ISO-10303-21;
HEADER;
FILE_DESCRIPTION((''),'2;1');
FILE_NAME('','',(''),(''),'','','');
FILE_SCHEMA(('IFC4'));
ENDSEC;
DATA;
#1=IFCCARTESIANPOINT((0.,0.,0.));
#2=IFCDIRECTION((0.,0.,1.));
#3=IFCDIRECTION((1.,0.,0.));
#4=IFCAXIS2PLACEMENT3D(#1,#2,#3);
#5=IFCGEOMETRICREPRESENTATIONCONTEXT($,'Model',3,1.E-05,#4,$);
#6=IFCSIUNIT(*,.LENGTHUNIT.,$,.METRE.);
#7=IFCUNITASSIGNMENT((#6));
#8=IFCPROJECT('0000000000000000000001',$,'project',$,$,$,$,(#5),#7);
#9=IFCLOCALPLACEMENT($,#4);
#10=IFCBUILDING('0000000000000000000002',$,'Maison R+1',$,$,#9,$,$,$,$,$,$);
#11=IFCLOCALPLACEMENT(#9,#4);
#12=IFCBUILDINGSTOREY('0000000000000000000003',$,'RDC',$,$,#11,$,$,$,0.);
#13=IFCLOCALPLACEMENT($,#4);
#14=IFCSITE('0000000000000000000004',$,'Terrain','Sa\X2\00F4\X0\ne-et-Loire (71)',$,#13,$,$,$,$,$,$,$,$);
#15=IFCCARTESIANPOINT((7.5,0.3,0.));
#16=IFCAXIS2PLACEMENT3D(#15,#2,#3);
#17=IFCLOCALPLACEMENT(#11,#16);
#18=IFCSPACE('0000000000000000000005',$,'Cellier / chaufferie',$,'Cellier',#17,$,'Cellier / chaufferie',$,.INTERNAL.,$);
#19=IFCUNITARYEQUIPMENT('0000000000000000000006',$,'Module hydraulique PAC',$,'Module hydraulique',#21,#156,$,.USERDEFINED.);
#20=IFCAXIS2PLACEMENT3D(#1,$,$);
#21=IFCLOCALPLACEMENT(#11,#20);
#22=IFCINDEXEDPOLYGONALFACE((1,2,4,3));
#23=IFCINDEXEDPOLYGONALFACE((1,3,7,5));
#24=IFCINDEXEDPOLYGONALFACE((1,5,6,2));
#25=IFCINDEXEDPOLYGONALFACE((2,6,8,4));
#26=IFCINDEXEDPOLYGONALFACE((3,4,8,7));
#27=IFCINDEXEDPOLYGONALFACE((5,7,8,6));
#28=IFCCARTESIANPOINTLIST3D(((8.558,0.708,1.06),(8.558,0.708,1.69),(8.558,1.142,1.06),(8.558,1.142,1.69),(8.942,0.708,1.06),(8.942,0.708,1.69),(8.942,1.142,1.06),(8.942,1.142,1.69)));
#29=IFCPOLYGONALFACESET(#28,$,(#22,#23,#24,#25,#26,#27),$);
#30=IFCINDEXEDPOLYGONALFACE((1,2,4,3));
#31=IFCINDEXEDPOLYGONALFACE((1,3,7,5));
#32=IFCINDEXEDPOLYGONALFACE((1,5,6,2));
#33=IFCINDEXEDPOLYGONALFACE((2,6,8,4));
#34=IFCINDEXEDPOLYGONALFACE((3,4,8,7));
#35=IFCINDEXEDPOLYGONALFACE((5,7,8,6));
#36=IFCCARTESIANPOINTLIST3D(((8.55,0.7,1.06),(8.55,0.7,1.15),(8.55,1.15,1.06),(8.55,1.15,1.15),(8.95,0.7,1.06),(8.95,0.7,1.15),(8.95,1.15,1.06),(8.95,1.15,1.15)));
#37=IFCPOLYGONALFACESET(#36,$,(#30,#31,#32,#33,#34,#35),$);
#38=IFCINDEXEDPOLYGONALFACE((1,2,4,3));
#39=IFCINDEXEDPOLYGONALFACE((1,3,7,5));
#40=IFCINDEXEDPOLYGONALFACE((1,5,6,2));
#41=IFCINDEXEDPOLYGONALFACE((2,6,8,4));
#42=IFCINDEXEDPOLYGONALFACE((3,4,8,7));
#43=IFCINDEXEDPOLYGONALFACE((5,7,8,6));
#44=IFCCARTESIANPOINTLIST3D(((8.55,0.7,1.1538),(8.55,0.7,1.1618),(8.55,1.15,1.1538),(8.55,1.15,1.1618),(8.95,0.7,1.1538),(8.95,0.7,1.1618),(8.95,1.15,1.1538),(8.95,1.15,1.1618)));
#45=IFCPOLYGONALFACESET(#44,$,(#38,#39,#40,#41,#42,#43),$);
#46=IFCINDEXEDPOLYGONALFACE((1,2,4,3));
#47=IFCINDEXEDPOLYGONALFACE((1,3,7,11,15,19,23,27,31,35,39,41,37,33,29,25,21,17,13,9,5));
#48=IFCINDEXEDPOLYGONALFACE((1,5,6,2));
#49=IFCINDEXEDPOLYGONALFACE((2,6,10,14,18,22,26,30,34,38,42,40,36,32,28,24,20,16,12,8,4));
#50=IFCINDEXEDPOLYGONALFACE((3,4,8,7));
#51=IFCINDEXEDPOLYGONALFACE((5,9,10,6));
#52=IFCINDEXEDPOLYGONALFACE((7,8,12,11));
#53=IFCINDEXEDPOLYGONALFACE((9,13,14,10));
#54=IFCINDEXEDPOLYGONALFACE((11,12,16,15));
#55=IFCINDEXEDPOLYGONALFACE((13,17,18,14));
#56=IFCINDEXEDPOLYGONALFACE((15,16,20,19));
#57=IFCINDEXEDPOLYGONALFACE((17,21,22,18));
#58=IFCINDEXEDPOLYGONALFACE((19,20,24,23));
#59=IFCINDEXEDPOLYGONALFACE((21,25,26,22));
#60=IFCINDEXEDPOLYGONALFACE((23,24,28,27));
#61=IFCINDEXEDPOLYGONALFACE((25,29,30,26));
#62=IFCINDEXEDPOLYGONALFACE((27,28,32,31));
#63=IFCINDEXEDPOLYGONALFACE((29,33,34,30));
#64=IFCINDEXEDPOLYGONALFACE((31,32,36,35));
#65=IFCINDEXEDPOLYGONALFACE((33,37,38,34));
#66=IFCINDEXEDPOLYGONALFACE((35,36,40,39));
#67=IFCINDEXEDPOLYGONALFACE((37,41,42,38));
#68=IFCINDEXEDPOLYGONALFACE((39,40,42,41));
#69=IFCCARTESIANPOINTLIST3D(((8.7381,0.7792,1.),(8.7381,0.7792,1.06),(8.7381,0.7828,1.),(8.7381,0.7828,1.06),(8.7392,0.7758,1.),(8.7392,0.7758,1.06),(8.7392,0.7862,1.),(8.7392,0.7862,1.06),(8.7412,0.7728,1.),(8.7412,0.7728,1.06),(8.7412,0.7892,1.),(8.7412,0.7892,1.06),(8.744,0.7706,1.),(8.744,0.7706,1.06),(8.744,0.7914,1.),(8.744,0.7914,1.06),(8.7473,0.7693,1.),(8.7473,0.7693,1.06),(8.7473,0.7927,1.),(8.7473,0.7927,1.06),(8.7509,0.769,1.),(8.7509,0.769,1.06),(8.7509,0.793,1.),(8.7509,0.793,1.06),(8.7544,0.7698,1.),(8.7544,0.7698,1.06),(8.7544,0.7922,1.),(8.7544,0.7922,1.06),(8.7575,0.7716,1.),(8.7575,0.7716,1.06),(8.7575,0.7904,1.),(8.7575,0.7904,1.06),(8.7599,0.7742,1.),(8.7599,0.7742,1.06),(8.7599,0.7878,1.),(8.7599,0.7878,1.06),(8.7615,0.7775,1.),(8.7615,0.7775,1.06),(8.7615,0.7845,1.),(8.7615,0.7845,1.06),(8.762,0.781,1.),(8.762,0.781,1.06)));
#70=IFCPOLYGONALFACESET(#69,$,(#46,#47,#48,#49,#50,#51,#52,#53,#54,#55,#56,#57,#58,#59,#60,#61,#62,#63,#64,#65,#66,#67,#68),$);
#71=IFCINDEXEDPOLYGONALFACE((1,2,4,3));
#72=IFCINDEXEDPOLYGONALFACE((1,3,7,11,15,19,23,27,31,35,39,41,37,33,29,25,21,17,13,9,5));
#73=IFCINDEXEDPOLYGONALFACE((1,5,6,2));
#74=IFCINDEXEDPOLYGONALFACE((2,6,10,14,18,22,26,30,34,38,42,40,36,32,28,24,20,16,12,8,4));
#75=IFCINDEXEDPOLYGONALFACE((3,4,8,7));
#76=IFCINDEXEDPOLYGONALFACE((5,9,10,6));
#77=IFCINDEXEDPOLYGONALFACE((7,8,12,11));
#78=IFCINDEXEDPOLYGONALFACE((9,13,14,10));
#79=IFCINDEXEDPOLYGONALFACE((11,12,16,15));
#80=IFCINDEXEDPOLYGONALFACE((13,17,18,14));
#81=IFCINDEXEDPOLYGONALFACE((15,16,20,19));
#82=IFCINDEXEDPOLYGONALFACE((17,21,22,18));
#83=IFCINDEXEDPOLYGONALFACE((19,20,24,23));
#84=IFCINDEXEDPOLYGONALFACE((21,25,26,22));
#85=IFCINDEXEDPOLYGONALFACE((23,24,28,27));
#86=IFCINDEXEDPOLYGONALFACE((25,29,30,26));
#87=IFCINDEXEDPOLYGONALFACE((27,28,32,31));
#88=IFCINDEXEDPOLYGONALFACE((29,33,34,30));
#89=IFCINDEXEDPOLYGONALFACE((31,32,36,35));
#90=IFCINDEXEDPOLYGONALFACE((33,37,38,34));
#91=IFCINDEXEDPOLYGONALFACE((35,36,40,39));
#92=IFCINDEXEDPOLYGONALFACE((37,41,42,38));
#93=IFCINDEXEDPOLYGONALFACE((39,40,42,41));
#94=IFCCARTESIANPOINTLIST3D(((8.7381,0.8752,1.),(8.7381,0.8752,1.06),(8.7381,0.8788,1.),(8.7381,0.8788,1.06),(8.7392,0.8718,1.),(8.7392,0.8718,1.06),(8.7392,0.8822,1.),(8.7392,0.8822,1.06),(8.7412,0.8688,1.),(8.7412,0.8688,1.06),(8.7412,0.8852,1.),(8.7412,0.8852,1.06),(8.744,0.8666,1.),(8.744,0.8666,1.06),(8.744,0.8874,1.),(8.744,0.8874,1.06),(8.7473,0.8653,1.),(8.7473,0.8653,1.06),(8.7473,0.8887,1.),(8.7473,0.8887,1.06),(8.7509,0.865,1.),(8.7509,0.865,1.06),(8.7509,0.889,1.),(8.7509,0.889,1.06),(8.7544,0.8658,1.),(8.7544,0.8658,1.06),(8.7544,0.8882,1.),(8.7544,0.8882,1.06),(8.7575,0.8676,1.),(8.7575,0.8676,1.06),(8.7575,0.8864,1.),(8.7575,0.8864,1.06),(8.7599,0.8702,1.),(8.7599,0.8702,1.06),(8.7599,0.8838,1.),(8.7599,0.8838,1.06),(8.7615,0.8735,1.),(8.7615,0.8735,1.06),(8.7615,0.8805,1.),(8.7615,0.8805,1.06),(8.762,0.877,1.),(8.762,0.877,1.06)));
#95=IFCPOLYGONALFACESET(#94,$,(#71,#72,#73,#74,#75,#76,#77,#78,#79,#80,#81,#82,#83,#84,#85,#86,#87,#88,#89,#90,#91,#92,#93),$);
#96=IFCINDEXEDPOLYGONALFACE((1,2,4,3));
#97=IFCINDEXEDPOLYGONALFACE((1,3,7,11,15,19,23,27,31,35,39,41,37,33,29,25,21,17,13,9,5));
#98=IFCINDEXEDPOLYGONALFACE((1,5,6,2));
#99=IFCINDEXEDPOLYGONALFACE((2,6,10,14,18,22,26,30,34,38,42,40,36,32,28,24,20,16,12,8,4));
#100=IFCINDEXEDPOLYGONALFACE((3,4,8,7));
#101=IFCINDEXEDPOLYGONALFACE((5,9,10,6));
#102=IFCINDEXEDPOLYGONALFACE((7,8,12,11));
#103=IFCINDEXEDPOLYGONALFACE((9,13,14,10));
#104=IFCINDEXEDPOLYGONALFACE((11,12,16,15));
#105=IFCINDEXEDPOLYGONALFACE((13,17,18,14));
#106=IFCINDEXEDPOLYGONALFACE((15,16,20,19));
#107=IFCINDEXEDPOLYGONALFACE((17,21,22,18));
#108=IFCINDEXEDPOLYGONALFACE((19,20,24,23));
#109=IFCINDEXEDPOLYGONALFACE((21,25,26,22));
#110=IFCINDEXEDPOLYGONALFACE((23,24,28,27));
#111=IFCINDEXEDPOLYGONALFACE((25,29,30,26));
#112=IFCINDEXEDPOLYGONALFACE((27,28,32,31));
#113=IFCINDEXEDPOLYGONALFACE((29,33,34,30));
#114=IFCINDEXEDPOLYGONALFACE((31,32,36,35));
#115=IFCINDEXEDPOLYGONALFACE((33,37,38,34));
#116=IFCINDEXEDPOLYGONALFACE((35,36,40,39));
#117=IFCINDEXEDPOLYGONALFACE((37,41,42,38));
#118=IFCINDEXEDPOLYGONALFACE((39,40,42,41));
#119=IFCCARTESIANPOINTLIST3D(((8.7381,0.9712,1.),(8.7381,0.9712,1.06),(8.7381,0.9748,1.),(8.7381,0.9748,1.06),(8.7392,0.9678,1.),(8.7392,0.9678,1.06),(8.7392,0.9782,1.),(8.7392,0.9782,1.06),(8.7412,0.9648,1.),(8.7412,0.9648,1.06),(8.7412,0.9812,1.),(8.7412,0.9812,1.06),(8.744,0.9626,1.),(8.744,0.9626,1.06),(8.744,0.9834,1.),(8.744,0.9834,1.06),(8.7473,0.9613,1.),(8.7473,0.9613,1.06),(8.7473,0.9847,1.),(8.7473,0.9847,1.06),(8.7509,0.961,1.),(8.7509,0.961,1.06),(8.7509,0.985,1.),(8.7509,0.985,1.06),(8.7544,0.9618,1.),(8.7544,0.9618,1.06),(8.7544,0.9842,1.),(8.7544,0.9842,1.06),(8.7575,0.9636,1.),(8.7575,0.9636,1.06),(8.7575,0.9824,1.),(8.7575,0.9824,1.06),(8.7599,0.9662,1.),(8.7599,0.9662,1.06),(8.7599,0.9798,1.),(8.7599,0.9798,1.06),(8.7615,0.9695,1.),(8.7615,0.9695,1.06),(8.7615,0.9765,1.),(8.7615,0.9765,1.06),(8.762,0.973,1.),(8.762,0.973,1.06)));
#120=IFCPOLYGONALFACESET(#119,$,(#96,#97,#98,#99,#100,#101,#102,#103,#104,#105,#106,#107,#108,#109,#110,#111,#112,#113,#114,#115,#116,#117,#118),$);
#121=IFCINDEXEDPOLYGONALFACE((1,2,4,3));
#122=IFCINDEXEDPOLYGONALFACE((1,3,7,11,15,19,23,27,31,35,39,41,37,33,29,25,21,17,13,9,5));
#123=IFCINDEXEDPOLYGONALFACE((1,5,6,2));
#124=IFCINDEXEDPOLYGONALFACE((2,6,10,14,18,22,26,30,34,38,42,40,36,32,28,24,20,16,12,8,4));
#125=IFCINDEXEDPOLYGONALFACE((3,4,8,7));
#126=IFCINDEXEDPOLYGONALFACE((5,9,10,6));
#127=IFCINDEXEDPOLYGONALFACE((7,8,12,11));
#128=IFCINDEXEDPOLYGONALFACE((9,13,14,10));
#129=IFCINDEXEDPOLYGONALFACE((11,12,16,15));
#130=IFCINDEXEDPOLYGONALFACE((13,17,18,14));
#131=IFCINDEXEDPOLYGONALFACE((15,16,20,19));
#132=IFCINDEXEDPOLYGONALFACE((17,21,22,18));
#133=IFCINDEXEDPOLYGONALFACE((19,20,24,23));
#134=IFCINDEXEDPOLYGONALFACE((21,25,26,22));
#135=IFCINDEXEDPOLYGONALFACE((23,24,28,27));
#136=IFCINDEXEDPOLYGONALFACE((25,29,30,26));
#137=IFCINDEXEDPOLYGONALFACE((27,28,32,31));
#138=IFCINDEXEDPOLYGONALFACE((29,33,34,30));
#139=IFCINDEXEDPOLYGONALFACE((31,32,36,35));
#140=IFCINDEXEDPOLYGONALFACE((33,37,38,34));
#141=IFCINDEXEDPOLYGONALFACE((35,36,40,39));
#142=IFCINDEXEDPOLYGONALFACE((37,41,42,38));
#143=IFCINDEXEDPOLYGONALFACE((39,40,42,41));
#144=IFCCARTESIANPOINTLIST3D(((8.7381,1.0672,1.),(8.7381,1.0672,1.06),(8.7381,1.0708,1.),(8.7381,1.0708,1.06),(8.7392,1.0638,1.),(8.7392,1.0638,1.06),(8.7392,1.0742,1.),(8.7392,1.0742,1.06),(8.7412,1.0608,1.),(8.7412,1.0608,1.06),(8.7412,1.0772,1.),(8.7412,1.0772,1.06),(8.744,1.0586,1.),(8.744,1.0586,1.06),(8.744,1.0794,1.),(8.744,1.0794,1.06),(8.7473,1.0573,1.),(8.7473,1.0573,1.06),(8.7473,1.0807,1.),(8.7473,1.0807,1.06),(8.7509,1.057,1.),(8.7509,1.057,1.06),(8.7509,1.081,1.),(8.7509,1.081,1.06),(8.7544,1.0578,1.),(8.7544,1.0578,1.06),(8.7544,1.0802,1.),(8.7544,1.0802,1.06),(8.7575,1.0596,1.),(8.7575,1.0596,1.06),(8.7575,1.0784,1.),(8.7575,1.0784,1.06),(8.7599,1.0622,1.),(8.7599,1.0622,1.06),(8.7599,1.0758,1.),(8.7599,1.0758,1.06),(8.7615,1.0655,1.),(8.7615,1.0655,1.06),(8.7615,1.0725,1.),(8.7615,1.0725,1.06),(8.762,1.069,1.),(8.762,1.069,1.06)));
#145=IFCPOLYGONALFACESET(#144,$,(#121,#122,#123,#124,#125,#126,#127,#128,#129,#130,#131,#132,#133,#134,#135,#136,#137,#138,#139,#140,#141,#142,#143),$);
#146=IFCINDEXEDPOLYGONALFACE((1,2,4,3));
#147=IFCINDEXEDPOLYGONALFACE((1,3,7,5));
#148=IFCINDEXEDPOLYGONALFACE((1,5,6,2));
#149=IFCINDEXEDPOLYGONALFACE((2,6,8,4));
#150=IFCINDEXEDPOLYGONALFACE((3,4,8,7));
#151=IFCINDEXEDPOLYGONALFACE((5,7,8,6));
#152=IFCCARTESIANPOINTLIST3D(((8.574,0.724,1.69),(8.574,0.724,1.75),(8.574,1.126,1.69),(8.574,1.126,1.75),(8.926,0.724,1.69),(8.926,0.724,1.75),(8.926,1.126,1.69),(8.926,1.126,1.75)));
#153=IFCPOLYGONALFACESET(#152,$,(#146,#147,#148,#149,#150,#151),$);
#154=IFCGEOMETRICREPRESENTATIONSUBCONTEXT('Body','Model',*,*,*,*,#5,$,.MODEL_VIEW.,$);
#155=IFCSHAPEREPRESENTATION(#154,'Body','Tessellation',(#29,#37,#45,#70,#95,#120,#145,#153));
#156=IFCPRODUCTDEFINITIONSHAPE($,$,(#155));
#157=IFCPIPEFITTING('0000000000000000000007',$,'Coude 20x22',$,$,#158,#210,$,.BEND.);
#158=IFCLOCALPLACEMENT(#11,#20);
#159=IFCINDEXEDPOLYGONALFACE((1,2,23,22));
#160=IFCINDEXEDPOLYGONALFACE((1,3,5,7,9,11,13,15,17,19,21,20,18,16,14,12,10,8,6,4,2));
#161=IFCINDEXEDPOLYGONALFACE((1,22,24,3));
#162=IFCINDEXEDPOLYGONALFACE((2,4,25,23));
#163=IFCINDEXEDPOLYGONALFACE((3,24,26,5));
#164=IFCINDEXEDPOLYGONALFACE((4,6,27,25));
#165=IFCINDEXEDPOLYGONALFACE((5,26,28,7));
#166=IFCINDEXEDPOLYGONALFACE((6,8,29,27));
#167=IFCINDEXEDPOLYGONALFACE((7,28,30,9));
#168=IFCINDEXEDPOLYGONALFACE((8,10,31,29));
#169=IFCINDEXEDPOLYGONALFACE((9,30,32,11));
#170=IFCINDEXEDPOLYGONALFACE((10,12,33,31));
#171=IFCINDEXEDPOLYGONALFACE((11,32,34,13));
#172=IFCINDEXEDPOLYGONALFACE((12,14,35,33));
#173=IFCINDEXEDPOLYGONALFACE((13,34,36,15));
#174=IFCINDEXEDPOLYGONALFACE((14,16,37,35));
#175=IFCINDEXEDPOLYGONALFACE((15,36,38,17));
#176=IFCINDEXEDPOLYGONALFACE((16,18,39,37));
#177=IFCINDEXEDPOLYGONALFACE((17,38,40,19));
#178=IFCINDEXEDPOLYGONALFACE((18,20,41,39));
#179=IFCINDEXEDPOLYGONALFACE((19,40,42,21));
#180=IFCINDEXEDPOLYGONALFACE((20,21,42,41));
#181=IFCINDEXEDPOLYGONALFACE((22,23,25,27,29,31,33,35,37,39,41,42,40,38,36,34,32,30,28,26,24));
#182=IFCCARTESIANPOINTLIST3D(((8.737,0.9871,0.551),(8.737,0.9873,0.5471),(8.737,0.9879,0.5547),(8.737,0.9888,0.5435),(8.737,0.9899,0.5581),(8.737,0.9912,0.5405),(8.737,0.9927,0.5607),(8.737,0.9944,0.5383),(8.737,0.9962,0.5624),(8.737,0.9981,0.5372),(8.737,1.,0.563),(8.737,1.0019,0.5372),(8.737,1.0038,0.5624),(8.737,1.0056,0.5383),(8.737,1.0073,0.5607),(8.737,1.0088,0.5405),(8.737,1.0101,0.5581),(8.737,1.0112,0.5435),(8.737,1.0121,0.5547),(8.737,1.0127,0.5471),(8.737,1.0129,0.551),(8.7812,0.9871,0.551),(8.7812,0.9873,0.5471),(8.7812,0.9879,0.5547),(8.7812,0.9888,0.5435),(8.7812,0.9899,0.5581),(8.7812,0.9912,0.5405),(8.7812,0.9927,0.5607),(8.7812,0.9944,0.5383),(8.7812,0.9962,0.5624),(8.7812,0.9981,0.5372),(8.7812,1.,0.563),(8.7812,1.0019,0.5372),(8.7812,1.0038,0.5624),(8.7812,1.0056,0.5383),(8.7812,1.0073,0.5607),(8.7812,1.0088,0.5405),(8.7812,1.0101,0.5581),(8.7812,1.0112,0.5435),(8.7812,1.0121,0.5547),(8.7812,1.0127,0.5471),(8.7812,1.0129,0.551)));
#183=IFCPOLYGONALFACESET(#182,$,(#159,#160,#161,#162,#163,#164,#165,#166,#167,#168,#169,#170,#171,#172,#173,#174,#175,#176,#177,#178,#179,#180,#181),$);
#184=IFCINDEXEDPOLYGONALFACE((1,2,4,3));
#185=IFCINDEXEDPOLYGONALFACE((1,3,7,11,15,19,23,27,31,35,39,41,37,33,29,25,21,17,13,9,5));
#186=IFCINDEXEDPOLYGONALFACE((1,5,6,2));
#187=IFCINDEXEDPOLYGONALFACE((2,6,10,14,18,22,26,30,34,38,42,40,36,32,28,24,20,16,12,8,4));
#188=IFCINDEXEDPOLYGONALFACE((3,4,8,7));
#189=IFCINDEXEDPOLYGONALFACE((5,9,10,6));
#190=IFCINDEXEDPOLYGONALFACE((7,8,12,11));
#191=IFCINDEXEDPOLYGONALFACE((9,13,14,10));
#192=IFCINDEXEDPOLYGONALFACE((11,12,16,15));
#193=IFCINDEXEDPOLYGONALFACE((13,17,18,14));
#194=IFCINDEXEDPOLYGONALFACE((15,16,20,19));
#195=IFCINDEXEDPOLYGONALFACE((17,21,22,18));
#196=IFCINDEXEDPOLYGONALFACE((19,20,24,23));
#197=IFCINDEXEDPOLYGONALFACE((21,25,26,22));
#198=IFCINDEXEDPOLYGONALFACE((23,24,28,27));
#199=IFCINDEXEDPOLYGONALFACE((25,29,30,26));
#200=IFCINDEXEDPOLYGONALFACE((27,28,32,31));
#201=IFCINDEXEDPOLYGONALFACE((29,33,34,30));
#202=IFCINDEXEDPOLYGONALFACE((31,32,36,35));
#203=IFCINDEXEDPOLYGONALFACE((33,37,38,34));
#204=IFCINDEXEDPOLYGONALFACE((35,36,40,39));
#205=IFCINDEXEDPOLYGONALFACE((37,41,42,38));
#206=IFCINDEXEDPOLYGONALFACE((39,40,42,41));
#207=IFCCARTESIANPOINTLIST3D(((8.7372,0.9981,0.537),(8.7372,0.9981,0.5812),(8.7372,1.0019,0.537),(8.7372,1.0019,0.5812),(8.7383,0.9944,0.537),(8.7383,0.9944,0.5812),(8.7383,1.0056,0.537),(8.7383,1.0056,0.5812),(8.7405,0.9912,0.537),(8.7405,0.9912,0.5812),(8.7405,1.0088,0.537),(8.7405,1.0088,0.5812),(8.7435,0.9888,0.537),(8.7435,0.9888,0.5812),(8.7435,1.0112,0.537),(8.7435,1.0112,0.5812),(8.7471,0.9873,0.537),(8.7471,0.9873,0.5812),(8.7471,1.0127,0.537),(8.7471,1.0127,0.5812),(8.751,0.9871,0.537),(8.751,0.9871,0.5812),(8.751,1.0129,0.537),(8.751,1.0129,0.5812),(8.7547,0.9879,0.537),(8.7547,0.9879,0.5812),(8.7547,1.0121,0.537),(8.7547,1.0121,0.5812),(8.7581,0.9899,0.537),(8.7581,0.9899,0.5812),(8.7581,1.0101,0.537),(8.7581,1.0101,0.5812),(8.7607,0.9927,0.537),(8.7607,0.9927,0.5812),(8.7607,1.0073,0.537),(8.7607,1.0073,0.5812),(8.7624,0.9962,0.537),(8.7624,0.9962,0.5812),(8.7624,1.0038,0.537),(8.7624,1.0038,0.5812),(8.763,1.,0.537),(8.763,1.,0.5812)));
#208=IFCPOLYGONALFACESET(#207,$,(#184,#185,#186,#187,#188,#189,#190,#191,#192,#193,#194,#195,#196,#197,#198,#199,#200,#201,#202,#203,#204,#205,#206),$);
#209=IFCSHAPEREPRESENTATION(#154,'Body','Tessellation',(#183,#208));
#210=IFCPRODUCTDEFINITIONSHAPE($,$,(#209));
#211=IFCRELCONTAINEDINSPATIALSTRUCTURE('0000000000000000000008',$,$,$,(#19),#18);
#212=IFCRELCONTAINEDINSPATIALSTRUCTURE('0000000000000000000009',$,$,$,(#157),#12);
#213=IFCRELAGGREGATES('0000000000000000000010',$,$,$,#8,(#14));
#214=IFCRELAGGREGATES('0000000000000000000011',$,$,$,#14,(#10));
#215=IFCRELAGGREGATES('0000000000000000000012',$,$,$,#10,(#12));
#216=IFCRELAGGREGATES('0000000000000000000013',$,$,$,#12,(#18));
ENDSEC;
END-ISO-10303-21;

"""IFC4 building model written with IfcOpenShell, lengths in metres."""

from ifc_helpers import new_model, si_unit, frame, frame_2d, origin_with_axes, place, context, subcontext, project, spatial, rectangle, circle, extrude, element, save


model = new_model("IFC4")

# Units and contexts
model_context = context("Model", 3, precision=1e-05, world=origin_with_axes())
body_context = subcontext(model_context, "Body", "Model", "MODEL_VIEW")
ifc_project = project(units=[si_unit("LENGTHUNIT", "METRE")], contexts=[model_context])

# Site, building, storey
site_placement = place(None, origin_with_axes())
site = spatial("IfcSite", under=ifc_project, at=site_placement, Name="Terrain", Description="Saône-et-Loire (71)")
building_placement = place(None, origin_with_axes())
building = spatial("IfcBuilding", under=site, at=building_placement, Name="Maison R+1")
storey_placement = place(building_placement, origin_with_axes())
storey = spatial("IfcBuildingStorey", under=building, at=storey_placement, Name="RDC", Elevation=0.0)

# Shared definitions
space_placement = place(storey_placement, frame((7.5, 0.3, 0.0), z_axis=(0.0, 0.0, 1.0), x_axis=(1.0, 0.0, 0.0)))
space = spatial("IfcSpace", under=storey, at=space_placement, Name="Cellier / chaufferie", ObjectType="Cellier", LongName="Cellier / chaufferie", PredefinedType="INTERNAL")

# Unitary equipment
unitary_equipment_1_placement = place(space_placement, frame((1.05, 0.4, 1.0), z_axis=(0.0, 0.0, 1.0), x_axis=(1.0, 0.0, 0.0)))
element("IfcUnitaryEquipment", 1, at=unitary_equipment_1_placement, inside=space, Name="Module hydraulique PAC", ObjectType="Module hydraulique", PredefinedType="USERDEFINED", context=body_context, shape_type="SweptSolid", body=[
    extrude(rectangle(XDim=0.384, YDim=0.434, at=frame_2d((0.192, 0.217))), frame((0.008, 0.008, 0.06), z_axis=(0.0, 0.0, 1.0), x_axis=(1.0, 0.0, 0.0)), (0.0, 0.0, 1.0), 0.63),
    extrude(rectangle(XDim=0.4, YDim=0.45, at=frame_2d((0.2, 0.225))), frame((0.0, 0.0, 0.06), z_axis=(0.0, 0.0, 1.0), x_axis=(1.0, 0.0, 0.0)), (0.0, 0.0, 1.0), 0.09),
    extrude(rectangle(XDim=0.4, YDim=0.45, at=frame_2d((0.2, 0.225))), frame((0.0, 0.0, 0.1537), z_axis=(0.0, 0.0, 1.0), x_axis=(1.0, 0.0, 0.0)), (0.0, 0.0, 1.0), 0.008),
    extrude(circle(Radius=0.012), frame((0.2, 0.081, 0.0), z_axis=(0.0, 0.0, 1.0), x_axis=(1.0, 0.0, 0.0)), (0.0, 0.0, 1.0), 0.06),
    extrude(circle(Radius=0.012), frame((0.2, 0.177, 0.0), z_axis=(0.0, 0.0, 1.0), x_axis=(1.0, 0.0, 0.0)), (0.0, 0.0, 1.0), 0.06),
    extrude(circle(Radius=0.012), frame((0.2, 0.273, 0.0), z_axis=(0.0, 0.0, 1.0), x_axis=(1.0, 0.0, 0.0)), (0.0, 0.0, 1.0), 0.06),
    extrude(circle(Radius=0.012), frame((0.2, 0.369, 0.0), z_axis=(0.0, 0.0, 1.0), x_axis=(1.0, 0.0, 0.0)), (0.0, 0.0, 1.0), 0.06),
    extrude(rectangle(XDim=0.352, YDim=0.402, at=frame_2d((0.176, 0.201))), frame((0.024, 0.024, 0.69), z_axis=(0.0, 0.0, 1.0), x_axis=(1.0, 0.0, 0.0)), (0.0, 0.0, 1.0), 0.06),
])

# Pipe fitting
for number, where, z_axis, x_axis, name in (
    (2, (8.75, 1.0, 0.55), (0.0, 0.0, 1.0), (1.0, 0.0, 0.0), "Coude 20x22"),
):
    element("IfcPipeFitting", number, at=place(storey_placement, frame(where, z_axis=z_axis, x_axis=x_axis)), inside=storey, Name=name, PredefinedType="BEND", context=body_context, shape_type="SweptSolid", body=[
        extrude(circle(Radius=0.013), frame((-0.013, 0.0, 0.0), z_axis=(1.0, 0.0, 0.0), x_axis=(0.0, 0.0, 1.0)), (0.0, 0.0, 1.0), 0.0441),
        extrude(circle(Radius=0.013), frame((0.0, 0.0, -0.013), z_axis=(0.0, 0.0, 1.0), x_axis=(1.0, 0.0, 0.0)), (0.0, 0.0, 1.0), 0.0441),
    ])

save(model, "model.ifc")
